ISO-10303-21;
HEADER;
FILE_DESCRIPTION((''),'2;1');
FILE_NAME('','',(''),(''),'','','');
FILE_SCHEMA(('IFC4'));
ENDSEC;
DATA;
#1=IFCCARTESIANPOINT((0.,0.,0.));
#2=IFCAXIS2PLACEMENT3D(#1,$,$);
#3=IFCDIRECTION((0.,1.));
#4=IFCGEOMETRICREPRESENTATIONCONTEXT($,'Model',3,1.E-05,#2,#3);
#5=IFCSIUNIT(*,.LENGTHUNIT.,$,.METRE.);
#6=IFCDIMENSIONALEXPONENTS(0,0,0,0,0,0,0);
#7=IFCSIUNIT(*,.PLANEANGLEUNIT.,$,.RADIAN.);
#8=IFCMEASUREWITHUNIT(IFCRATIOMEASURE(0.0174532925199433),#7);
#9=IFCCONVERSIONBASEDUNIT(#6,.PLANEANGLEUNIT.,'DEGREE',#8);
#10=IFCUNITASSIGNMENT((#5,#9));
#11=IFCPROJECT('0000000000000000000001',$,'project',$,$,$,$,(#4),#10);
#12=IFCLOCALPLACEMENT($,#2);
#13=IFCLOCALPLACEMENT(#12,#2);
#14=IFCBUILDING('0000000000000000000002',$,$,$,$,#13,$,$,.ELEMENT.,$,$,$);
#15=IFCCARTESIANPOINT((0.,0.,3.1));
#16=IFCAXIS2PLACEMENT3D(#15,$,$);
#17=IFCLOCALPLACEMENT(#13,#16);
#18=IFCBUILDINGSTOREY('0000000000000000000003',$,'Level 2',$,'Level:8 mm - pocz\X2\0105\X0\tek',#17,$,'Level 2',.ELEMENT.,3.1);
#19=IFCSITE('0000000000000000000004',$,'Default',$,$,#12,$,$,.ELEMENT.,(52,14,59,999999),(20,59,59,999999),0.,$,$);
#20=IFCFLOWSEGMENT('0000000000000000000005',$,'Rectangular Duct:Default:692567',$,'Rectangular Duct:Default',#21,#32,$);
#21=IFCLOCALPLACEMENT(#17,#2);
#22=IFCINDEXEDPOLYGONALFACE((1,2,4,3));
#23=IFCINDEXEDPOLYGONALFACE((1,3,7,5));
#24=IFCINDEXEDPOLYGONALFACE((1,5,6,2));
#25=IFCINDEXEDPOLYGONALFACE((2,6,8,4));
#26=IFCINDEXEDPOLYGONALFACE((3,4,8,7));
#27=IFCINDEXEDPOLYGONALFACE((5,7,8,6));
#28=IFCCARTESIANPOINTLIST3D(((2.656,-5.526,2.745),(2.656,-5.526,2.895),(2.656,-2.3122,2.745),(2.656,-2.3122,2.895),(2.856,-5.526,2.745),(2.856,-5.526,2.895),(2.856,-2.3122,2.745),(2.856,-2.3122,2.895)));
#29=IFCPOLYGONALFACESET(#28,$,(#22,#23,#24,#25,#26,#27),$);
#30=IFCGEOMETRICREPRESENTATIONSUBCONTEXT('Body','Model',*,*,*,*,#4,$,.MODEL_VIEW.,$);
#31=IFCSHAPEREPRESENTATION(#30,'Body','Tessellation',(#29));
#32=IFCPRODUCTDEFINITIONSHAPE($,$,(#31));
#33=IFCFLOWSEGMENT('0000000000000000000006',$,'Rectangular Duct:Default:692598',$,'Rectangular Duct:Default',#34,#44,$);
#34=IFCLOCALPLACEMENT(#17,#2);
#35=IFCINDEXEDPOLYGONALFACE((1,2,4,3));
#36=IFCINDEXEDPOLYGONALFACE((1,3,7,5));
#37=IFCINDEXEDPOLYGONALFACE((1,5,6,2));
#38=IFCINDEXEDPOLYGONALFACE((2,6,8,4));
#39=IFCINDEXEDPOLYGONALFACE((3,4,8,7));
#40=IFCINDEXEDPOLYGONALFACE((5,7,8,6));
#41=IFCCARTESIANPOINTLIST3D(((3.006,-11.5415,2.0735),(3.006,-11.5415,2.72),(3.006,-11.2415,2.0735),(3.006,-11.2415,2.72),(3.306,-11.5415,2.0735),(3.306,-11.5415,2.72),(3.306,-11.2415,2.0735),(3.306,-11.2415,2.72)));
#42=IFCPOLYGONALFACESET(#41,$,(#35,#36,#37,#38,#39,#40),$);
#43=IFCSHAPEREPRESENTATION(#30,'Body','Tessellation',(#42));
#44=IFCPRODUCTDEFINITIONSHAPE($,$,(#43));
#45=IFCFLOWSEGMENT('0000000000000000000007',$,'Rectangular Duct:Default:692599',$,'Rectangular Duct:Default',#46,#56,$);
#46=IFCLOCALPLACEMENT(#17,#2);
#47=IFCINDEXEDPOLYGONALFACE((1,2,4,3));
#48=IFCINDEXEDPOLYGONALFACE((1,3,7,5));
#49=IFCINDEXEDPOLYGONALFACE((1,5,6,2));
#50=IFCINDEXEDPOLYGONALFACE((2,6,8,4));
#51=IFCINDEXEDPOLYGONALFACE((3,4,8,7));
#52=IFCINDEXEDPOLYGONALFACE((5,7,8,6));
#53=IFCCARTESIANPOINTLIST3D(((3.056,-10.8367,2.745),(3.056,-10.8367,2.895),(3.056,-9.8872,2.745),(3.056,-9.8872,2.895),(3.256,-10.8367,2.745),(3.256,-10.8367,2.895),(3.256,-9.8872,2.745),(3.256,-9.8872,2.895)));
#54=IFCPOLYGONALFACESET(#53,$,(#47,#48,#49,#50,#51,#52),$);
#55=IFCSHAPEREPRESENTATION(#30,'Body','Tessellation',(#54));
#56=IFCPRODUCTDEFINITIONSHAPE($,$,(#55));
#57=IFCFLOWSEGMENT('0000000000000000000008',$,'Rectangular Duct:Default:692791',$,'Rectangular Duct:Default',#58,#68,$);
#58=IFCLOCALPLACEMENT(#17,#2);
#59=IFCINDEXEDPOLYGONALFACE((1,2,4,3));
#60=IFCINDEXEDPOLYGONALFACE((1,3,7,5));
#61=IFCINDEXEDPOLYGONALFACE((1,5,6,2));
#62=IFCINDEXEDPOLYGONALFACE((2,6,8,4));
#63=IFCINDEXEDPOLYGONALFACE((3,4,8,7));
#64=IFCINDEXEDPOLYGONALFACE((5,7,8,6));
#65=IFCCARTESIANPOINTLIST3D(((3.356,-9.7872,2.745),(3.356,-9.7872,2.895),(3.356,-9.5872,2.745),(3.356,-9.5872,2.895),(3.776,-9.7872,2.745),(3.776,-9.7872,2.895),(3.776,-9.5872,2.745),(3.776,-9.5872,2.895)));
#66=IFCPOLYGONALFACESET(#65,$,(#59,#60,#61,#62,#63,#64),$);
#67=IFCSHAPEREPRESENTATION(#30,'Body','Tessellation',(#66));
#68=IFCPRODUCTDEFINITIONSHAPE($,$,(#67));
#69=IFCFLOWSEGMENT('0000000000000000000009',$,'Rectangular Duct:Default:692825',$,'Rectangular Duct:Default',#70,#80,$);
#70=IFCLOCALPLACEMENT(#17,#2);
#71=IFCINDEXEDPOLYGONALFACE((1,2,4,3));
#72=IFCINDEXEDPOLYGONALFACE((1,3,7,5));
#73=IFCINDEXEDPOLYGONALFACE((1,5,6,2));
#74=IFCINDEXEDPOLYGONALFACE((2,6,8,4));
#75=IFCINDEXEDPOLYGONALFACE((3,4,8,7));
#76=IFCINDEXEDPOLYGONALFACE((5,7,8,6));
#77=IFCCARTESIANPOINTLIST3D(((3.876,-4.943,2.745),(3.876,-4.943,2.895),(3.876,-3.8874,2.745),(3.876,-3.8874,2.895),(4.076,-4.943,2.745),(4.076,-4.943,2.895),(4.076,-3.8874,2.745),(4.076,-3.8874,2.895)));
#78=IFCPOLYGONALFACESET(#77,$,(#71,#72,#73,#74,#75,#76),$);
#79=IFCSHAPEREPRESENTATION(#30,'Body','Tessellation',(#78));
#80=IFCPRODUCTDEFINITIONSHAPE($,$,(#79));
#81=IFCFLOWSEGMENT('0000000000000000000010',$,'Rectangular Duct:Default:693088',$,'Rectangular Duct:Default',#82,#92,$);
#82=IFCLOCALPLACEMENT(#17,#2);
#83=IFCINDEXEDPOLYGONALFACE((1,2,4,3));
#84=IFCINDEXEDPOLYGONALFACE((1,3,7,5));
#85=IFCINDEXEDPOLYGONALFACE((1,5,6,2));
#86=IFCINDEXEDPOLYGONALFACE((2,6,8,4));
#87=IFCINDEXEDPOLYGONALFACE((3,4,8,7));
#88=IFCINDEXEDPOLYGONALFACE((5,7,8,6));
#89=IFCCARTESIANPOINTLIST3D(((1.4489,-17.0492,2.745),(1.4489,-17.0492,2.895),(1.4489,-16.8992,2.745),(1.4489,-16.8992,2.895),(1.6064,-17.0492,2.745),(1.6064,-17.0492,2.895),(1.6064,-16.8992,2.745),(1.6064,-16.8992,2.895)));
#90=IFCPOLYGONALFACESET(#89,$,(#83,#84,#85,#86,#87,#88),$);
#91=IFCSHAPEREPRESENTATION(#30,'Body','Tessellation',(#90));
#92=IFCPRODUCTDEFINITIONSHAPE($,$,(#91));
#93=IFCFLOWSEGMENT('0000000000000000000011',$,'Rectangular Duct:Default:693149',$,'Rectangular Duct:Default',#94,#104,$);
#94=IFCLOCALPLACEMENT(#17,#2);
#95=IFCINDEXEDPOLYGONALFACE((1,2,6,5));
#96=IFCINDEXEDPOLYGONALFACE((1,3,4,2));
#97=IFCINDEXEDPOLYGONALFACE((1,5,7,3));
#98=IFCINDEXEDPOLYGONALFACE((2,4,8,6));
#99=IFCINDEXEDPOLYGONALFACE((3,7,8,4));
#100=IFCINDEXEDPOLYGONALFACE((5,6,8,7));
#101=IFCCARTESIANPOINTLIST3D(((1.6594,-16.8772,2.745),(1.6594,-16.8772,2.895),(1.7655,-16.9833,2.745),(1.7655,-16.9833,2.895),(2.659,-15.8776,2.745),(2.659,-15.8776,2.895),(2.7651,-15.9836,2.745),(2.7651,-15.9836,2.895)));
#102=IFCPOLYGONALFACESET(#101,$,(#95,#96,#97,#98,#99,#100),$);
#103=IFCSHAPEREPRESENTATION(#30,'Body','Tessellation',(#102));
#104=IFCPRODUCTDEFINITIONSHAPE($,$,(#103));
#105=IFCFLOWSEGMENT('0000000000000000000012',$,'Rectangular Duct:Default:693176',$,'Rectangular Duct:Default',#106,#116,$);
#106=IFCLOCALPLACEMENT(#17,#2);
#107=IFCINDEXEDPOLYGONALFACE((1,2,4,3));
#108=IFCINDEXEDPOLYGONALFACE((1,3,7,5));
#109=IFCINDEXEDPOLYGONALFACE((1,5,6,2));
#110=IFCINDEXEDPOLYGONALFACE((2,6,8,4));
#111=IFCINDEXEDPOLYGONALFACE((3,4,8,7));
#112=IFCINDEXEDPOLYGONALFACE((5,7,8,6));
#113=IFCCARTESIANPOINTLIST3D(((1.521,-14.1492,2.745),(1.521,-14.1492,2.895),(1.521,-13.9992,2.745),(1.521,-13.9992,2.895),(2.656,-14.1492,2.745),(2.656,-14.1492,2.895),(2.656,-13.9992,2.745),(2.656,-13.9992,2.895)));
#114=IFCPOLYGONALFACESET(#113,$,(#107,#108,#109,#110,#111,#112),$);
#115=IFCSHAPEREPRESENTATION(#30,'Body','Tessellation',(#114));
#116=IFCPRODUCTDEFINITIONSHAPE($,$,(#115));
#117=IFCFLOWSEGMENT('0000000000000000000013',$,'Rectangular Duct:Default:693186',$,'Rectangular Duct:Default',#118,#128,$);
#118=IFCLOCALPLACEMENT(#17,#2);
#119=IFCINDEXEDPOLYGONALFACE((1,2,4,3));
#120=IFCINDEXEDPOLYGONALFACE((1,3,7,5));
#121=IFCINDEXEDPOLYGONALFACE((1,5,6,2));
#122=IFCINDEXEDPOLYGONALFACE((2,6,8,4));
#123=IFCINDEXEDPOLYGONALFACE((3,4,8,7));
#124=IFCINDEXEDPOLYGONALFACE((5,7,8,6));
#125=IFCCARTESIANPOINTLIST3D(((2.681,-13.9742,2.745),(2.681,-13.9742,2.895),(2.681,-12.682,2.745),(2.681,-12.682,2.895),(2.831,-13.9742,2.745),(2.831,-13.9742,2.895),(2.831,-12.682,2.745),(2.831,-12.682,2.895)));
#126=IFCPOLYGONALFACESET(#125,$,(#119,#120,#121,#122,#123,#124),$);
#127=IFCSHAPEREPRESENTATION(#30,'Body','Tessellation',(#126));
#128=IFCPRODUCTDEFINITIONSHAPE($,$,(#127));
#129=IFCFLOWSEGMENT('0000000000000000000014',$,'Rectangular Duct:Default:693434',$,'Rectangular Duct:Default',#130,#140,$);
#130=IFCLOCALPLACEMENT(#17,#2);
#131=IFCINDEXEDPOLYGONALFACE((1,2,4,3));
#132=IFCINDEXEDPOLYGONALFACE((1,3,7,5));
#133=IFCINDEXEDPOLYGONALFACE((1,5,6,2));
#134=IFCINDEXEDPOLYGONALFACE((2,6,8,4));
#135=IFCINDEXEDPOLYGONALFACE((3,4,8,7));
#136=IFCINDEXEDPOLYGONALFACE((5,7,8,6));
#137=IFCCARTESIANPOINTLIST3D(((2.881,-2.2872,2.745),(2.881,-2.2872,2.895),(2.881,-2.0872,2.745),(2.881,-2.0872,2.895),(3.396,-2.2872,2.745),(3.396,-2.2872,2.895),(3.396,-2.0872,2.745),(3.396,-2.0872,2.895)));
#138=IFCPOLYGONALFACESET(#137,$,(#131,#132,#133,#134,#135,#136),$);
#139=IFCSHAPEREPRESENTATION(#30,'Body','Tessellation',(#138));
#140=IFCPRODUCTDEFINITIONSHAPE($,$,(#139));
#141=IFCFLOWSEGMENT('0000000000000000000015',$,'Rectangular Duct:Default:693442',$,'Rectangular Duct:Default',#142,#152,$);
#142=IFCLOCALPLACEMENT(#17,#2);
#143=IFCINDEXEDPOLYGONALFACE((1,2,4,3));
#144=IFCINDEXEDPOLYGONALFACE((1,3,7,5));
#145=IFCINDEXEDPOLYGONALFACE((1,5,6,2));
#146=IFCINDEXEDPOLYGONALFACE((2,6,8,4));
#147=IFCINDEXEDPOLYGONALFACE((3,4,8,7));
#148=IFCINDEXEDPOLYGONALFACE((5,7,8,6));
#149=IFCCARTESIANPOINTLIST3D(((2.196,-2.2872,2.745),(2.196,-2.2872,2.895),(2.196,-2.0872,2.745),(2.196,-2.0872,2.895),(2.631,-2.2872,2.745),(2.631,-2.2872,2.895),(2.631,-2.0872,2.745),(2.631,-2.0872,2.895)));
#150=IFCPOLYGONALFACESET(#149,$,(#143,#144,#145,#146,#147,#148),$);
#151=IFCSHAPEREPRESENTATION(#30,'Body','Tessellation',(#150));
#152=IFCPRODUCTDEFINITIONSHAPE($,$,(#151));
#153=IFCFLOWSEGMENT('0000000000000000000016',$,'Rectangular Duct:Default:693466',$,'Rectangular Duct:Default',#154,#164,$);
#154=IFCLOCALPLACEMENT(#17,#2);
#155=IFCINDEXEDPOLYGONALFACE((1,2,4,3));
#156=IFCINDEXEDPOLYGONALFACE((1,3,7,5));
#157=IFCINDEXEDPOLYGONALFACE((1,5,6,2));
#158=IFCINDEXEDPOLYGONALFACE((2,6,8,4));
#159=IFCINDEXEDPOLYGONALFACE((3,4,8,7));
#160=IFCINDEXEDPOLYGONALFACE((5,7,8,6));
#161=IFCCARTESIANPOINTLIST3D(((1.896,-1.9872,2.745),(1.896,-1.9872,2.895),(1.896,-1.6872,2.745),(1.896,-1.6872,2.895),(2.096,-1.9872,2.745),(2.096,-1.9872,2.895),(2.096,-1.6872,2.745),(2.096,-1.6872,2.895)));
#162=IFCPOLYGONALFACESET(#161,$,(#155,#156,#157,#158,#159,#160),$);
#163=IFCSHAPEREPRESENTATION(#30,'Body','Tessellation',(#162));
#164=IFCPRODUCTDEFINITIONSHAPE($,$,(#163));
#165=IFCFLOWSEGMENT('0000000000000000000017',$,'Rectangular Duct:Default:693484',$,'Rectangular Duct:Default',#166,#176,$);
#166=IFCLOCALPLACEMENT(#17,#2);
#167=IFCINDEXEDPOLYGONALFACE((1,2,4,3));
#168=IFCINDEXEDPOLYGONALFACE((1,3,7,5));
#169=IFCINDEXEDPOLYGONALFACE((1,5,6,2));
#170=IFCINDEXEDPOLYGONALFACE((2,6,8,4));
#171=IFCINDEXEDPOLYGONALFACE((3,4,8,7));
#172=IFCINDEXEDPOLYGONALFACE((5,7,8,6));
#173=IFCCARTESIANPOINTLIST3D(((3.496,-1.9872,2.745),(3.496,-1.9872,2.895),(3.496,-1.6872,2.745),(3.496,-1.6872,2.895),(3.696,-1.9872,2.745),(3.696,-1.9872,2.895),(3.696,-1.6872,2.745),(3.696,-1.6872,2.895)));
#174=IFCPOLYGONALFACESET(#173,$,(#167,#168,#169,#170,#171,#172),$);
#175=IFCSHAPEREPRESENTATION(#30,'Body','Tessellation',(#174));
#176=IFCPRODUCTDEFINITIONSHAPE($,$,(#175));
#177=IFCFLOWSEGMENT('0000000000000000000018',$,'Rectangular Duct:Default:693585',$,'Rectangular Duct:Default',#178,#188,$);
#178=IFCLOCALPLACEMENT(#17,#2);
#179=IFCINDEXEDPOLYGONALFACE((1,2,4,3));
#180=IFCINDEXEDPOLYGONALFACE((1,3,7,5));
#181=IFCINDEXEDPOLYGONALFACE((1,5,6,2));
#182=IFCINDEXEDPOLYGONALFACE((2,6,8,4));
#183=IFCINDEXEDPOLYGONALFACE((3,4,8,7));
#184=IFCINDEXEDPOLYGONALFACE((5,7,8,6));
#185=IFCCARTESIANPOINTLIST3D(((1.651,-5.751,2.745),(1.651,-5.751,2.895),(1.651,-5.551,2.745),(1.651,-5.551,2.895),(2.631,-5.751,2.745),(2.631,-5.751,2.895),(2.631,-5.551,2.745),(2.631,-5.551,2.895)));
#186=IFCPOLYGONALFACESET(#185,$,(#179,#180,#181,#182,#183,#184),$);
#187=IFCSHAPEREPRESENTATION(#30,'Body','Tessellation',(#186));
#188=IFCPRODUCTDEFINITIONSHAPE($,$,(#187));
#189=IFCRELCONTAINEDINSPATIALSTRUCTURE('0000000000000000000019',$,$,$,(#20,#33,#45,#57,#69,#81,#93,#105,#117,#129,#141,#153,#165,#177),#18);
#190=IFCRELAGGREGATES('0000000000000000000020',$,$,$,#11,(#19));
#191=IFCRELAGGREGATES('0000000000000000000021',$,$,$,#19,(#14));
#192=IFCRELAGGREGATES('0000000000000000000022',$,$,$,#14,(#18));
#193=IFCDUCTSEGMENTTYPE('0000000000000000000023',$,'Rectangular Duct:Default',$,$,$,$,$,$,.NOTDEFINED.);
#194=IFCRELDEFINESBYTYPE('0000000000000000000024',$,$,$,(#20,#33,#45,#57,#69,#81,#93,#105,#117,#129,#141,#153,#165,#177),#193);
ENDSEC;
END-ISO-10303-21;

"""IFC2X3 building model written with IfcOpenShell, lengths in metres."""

from ifc_helpers import new_model, entity, si_unit, converted_unit, direction, frame, frame_2d, origin, origin_2d_with_axis, place, context, subcontext, project, spatial, rectangle, extrude, type_object, element, save


model = new_model("IFC2X3")

# Units and contexts
model_context = context("Model", 3, precision=1e-05, world=origin(), true_north=direction((0.0, 1.0)))
body_context = subcontext(model_context, "Body", "Model", "MODEL_VIEW")
ifc_project = project(units=[si_unit("LENGTHUNIT", "METRE"), converted_unit("PLANEANGLEUNIT", "DEGREE", entity("IfcRatioMeasure", 0.0174532925199433), si_unit("PLANEANGLEUNIT", "RADIAN"), dimensions=[0, 0, 0, 0, 0, 0, 0])], contexts=[model_context])

# Site, building, storey
site_placement = place(None, origin())
site = spatial("IfcSite", under=ifc_project, at=site_placement, Name="Default", CompositionType="ELEMENT", RefLatitude=(52, 14, 59, 999999), RefLongitude=(20, 59, 59, 999999), RefElevation=0.0)
building_placement = place(site_placement, origin())
building = spatial("IfcBuilding", under=site, at=building_placement, CompositionType="ELEMENT")
storey_placement = place(building_placement, frame((0.0, 0.0, 3.1)))
storey = spatial("IfcBuildingStorey", under=building, at=storey_placement, Name="Level 2", ObjectType="Level:8 mm - początek", LongName="Level 2", CompositionType="ELEMENT", Elevation=3.1)

# Flow segments
duct_segment_type = type_object("IfcDuctSegmentType", Name="Rectangular Duct:Default", PredefinedType="NOTDEFINED")
flow_segment_1_placement = place(storey_placement, origin())
element("IfcFlowSegment", 1, at=flow_segment_1_placement, inside=storey, type_object=duct_segment_type, Name="Rectangular Duct:Default:692567", ObjectType="Rectangular Duct:Default", context=body_context, shape_type="SweptSolid", body=[
    extrude(rectangle(XDim=3.2138, YDim=0.2, at=frame_2d((0.0, 0.0), x_axis=(1.0, 0.0))), frame((2.756, -3.9191, 2.745), z_axis=(0.0, 0.0, 1.0), x_axis=(0.0, 1.0, 0.0)), (0.0, 0.0, 1.0), 0.15),
])
flow_segment_2_placement = place(storey_placement, origin())
element("IfcFlowSegment", 2, at=flow_segment_2_placement, inside=storey, type_object=duct_segment_type, Name="Rectangular Duct:Default:692598", ObjectType="Rectangular Duct:Default", context=body_context, shape_type="SweptSolid", body=[
    extrude(rectangle(XDim=0.3, YDim=0.3, at=origin_2d_with_axis()), frame((3.156, -11.3915, 2.0735), z_axis=(0.0, 0.0, 1.0), x_axis=(0.0, -1.0, 0.0)), (0.0, 0.0, 1.0), 0.6465),
])
flow_segment_3_placement = place(storey_placement, origin())
element("IfcFlowSegment", 3, at=flow_segment_3_placement, inside=storey, type_object=duct_segment_type, Name="Rectangular Duct:Default:692599", ObjectType="Rectangular Duct:Default", context=body_context, shape_type="SweptSolid", body=[
    extrude(rectangle(XDim=0.9495, YDim=0.2, at=frame_2d((0.0, 0.0), x_axis=(1.0, 0.0))), frame((3.156, -10.362, 2.745), z_axis=(0.0, 0.0, 1.0), x_axis=(0.0, 1.0, 0.0)), (0.0, 0.0, 1.0), 0.15),
])
flow_segment_4_placement = place(storey_placement, origin())
element("IfcFlowSegment", 4, at=flow_segment_4_placement, inside=storey, type_object=duct_segment_type, Name="Rectangular Duct:Default:692791", ObjectType="Rectangular Duct:Default", context=body_context, shape_type="SweptSolid", body=[
    extrude(rectangle(XDim=0.42, YDim=0.2, at=frame_2d((0.0, 0.0), x_axis=(1.0, 0.0))), frame((3.566, -9.6872, 2.745)), (0.0, 0.0, 1.0), 0.15),
])
flow_segment_5_placement = place(storey_placement, origin())
element("IfcFlowSegment", 5, at=flow_segment_5_placement, inside=storey, type_object=duct_segment_type, Name="Rectangular Duct:Default:692825", ObjectType="Rectangular Duct:Default", context=body_context, shape_type="SweptSolid", body=[
    extrude(rectangle(XDim=1.0556, YDim=0.2, at=frame_2d((0.0, 0.0), x_axis=(1.0, 0.0))), frame((3.976, -4.4152, 2.745), z_axis=(0.0, 0.0, 1.0), x_axis=(0.0, 1.0, 0.0)), (0.0, 0.0, 1.0), 0.15),
])
flow_segment_6_placement = place(storey_placement, origin())
element("IfcFlowSegment", 6, at=flow_segment_6_placement, inside=storey, type_object=duct_segment_type, Name="Rectangular Duct:Default:693088", ObjectType="Rectangular Duct:Default", context=body_context, shape_type="SweptSolid", body=[
    extrude(rectangle(XDim=0.1575, YDim=0.15, at=frame_2d((0.0, 0.0), x_axis=(1.0, 0.0))), frame((1.5276, -16.9742, 2.745), z_axis=(0.0, 0.0, 1.0), x_axis=(-1.0, 0.0, 0.0)), (0.0, 0.0, 1.0), 0.15),
])
flow_segment_7_placement = place(storey_placement, origin())
element("IfcFlowSegment", 7, at=flow_segment_7_placement, inside=storey, type_object=duct_segment_type, Name="Rectangular Duct:Default:693149", ObjectType="Rectangular Duct:Default", context=body_context, shape_type="SweptSolid", body=[
    extrude(rectangle(XDim=1.4137, YDim=0.15, at=origin_2d_with_axis()), frame((2.2123, -16.4304, 2.745), z_axis=(0.0, 0.0, 1.0), x_axis=(-0.707107, -0.707107, 0.0)), (0.0, 0.0, 1.0), 0.15),
])
flow_segment_8_placement = place(storey_placement, origin())
element("IfcFlowSegment", 8, at=flow_segment_8_placement, inside=storey, type_object=duct_segment_type, Name="Rectangular Duct:Default:693176", ObjectType="Rectangular Duct:Default", context=body_context, shape_type="SweptSolid", body=[
    extrude(rectangle(XDim=1.135, YDim=0.15, at=frame_2d((0.0, 0.0), x_axis=(1.0, 0.0))), frame((2.0885, -14.0742, 2.745), z_axis=(0.0, 0.0, 1.0), x_axis=(-1.0, 0.0, 0.0)), (0.0, 0.0, 1.0), 0.15),
])
flow_segment_9_placement = place(storey_placement, origin())
element("IfcFlowSegment", 9, at=flow_segment_9_placement, inside=storey, type_object=duct_segment_type, Name="Rectangular Duct:Default:693186", ObjectType="Rectangular Duct:Default", context=body_context, shape_type="SweptSolid", body=[
    extrude(rectangle(XDim=1.2921, YDim=0.15, at=frame_2d((0.0, 0.0), x_axis=(1.0, 0.0))), frame((2.756, -13.3281, 2.745), z_axis=(0.0, 0.0, 1.0), x_axis=(0.0, -1.0, 0.0)), (0.0, 0.0, 1.0), 0.15),
])
flow_segment_10_placement = place(storey_placement, origin())
element("IfcFlowSegment", 10, at=flow_segment_10_placement, inside=storey, type_object=duct_segment_type, Name="Rectangular Duct:Default:693434", ObjectType="Rectangular Duct:Default", context=body_context, shape_type="SweptSolid", body=[
    extrude(rectangle(XDim=0.515, YDim=0.2, at=frame_2d((0.0, 0.0), x_axis=(1.0, 0.0))), frame((3.1385, -2.1872, 2.745)), (0.0, 0.0, 1.0), 0.15),
])
flow_segment_11_placement = place(storey_placement, origin())
element("IfcFlowSegment", 11, at=flow_segment_11_placement, inside=storey, type_object=duct_segment_type, Name="Rectangular Duct:Default:693442", ObjectType="Rectangular Duct:Default", context=body_context, shape_type="SweptSolid", body=[
    extrude(rectangle(XDim=0.435, YDim=0.2, at=frame_2d((0.0, 0.0), x_axis=(1.0, 0.0))), frame((2.4135, -2.1872, 2.745)), (0.0, 0.0, 1.0), 0.15),
])
flow_segment_12_placement = place(storey_placement, origin())
element("IfcFlowSegment", 12, at=flow_segment_12_placement, inside=storey, type_object=duct_segment_type, Name="Rectangular Duct:Default:693466", ObjectType="Rectangular Duct:Default", context=body_context, shape_type="SweptSolid", body=[
    extrude(rectangle(XDim=0.3, YDim=0.2, at=frame_2d((0.0, 0.0), x_axis=(1.0, 0.0))), frame((1.996, -1.8372, 2.745), z_axis=(0.0, 0.0, 1.0), x_axis=(0.0, 1.0, 0.0)), (0.0, 0.0, 1.0), 0.15),
])
flow_segment_13_placement = place(storey_placement, origin())
element("IfcFlowSegment", 13, at=flow_segment_13_placement, inside=storey, type_object=duct_segment_type, Name="Rectangular Duct:Default:693484", ObjectType="Rectangular Duct:Default", context=body_context, shape_type="SweptSolid", body=[
    extrude(rectangle(XDim=0.3, YDim=0.2, at=frame_2d((0.0, 0.0), x_axis=(1.0, 0.0))), frame((3.596, -1.8372, 2.745), z_axis=(0.0, 0.0, 1.0), x_axis=(0.0, 1.0, 0.0)), (0.0, 0.0, 1.0), 0.15),
])
flow_segment_14_placement = place(storey_placement, origin())
element("IfcFlowSegment", 14, at=flow_segment_14_placement, inside=storey, type_object=duct_segment_type, Name="Rectangular Duct:Default:693585", ObjectType="Rectangular Duct:Default", context=body_context, shape_type="SweptSolid", body=[
    extrude(rectangle(XDim=0.98, YDim=0.2, at=frame_2d((0.0, 0.0), x_axis=(1.0, 0.0))), frame((2.141, -5.651, 2.745), z_axis=(0.0, 0.0, 1.0), x_axis=(-1.0, 0.0, 0.0)), (0.0, 0.0, 1.0), 0.15),
])

save(model, "model.ifc")
